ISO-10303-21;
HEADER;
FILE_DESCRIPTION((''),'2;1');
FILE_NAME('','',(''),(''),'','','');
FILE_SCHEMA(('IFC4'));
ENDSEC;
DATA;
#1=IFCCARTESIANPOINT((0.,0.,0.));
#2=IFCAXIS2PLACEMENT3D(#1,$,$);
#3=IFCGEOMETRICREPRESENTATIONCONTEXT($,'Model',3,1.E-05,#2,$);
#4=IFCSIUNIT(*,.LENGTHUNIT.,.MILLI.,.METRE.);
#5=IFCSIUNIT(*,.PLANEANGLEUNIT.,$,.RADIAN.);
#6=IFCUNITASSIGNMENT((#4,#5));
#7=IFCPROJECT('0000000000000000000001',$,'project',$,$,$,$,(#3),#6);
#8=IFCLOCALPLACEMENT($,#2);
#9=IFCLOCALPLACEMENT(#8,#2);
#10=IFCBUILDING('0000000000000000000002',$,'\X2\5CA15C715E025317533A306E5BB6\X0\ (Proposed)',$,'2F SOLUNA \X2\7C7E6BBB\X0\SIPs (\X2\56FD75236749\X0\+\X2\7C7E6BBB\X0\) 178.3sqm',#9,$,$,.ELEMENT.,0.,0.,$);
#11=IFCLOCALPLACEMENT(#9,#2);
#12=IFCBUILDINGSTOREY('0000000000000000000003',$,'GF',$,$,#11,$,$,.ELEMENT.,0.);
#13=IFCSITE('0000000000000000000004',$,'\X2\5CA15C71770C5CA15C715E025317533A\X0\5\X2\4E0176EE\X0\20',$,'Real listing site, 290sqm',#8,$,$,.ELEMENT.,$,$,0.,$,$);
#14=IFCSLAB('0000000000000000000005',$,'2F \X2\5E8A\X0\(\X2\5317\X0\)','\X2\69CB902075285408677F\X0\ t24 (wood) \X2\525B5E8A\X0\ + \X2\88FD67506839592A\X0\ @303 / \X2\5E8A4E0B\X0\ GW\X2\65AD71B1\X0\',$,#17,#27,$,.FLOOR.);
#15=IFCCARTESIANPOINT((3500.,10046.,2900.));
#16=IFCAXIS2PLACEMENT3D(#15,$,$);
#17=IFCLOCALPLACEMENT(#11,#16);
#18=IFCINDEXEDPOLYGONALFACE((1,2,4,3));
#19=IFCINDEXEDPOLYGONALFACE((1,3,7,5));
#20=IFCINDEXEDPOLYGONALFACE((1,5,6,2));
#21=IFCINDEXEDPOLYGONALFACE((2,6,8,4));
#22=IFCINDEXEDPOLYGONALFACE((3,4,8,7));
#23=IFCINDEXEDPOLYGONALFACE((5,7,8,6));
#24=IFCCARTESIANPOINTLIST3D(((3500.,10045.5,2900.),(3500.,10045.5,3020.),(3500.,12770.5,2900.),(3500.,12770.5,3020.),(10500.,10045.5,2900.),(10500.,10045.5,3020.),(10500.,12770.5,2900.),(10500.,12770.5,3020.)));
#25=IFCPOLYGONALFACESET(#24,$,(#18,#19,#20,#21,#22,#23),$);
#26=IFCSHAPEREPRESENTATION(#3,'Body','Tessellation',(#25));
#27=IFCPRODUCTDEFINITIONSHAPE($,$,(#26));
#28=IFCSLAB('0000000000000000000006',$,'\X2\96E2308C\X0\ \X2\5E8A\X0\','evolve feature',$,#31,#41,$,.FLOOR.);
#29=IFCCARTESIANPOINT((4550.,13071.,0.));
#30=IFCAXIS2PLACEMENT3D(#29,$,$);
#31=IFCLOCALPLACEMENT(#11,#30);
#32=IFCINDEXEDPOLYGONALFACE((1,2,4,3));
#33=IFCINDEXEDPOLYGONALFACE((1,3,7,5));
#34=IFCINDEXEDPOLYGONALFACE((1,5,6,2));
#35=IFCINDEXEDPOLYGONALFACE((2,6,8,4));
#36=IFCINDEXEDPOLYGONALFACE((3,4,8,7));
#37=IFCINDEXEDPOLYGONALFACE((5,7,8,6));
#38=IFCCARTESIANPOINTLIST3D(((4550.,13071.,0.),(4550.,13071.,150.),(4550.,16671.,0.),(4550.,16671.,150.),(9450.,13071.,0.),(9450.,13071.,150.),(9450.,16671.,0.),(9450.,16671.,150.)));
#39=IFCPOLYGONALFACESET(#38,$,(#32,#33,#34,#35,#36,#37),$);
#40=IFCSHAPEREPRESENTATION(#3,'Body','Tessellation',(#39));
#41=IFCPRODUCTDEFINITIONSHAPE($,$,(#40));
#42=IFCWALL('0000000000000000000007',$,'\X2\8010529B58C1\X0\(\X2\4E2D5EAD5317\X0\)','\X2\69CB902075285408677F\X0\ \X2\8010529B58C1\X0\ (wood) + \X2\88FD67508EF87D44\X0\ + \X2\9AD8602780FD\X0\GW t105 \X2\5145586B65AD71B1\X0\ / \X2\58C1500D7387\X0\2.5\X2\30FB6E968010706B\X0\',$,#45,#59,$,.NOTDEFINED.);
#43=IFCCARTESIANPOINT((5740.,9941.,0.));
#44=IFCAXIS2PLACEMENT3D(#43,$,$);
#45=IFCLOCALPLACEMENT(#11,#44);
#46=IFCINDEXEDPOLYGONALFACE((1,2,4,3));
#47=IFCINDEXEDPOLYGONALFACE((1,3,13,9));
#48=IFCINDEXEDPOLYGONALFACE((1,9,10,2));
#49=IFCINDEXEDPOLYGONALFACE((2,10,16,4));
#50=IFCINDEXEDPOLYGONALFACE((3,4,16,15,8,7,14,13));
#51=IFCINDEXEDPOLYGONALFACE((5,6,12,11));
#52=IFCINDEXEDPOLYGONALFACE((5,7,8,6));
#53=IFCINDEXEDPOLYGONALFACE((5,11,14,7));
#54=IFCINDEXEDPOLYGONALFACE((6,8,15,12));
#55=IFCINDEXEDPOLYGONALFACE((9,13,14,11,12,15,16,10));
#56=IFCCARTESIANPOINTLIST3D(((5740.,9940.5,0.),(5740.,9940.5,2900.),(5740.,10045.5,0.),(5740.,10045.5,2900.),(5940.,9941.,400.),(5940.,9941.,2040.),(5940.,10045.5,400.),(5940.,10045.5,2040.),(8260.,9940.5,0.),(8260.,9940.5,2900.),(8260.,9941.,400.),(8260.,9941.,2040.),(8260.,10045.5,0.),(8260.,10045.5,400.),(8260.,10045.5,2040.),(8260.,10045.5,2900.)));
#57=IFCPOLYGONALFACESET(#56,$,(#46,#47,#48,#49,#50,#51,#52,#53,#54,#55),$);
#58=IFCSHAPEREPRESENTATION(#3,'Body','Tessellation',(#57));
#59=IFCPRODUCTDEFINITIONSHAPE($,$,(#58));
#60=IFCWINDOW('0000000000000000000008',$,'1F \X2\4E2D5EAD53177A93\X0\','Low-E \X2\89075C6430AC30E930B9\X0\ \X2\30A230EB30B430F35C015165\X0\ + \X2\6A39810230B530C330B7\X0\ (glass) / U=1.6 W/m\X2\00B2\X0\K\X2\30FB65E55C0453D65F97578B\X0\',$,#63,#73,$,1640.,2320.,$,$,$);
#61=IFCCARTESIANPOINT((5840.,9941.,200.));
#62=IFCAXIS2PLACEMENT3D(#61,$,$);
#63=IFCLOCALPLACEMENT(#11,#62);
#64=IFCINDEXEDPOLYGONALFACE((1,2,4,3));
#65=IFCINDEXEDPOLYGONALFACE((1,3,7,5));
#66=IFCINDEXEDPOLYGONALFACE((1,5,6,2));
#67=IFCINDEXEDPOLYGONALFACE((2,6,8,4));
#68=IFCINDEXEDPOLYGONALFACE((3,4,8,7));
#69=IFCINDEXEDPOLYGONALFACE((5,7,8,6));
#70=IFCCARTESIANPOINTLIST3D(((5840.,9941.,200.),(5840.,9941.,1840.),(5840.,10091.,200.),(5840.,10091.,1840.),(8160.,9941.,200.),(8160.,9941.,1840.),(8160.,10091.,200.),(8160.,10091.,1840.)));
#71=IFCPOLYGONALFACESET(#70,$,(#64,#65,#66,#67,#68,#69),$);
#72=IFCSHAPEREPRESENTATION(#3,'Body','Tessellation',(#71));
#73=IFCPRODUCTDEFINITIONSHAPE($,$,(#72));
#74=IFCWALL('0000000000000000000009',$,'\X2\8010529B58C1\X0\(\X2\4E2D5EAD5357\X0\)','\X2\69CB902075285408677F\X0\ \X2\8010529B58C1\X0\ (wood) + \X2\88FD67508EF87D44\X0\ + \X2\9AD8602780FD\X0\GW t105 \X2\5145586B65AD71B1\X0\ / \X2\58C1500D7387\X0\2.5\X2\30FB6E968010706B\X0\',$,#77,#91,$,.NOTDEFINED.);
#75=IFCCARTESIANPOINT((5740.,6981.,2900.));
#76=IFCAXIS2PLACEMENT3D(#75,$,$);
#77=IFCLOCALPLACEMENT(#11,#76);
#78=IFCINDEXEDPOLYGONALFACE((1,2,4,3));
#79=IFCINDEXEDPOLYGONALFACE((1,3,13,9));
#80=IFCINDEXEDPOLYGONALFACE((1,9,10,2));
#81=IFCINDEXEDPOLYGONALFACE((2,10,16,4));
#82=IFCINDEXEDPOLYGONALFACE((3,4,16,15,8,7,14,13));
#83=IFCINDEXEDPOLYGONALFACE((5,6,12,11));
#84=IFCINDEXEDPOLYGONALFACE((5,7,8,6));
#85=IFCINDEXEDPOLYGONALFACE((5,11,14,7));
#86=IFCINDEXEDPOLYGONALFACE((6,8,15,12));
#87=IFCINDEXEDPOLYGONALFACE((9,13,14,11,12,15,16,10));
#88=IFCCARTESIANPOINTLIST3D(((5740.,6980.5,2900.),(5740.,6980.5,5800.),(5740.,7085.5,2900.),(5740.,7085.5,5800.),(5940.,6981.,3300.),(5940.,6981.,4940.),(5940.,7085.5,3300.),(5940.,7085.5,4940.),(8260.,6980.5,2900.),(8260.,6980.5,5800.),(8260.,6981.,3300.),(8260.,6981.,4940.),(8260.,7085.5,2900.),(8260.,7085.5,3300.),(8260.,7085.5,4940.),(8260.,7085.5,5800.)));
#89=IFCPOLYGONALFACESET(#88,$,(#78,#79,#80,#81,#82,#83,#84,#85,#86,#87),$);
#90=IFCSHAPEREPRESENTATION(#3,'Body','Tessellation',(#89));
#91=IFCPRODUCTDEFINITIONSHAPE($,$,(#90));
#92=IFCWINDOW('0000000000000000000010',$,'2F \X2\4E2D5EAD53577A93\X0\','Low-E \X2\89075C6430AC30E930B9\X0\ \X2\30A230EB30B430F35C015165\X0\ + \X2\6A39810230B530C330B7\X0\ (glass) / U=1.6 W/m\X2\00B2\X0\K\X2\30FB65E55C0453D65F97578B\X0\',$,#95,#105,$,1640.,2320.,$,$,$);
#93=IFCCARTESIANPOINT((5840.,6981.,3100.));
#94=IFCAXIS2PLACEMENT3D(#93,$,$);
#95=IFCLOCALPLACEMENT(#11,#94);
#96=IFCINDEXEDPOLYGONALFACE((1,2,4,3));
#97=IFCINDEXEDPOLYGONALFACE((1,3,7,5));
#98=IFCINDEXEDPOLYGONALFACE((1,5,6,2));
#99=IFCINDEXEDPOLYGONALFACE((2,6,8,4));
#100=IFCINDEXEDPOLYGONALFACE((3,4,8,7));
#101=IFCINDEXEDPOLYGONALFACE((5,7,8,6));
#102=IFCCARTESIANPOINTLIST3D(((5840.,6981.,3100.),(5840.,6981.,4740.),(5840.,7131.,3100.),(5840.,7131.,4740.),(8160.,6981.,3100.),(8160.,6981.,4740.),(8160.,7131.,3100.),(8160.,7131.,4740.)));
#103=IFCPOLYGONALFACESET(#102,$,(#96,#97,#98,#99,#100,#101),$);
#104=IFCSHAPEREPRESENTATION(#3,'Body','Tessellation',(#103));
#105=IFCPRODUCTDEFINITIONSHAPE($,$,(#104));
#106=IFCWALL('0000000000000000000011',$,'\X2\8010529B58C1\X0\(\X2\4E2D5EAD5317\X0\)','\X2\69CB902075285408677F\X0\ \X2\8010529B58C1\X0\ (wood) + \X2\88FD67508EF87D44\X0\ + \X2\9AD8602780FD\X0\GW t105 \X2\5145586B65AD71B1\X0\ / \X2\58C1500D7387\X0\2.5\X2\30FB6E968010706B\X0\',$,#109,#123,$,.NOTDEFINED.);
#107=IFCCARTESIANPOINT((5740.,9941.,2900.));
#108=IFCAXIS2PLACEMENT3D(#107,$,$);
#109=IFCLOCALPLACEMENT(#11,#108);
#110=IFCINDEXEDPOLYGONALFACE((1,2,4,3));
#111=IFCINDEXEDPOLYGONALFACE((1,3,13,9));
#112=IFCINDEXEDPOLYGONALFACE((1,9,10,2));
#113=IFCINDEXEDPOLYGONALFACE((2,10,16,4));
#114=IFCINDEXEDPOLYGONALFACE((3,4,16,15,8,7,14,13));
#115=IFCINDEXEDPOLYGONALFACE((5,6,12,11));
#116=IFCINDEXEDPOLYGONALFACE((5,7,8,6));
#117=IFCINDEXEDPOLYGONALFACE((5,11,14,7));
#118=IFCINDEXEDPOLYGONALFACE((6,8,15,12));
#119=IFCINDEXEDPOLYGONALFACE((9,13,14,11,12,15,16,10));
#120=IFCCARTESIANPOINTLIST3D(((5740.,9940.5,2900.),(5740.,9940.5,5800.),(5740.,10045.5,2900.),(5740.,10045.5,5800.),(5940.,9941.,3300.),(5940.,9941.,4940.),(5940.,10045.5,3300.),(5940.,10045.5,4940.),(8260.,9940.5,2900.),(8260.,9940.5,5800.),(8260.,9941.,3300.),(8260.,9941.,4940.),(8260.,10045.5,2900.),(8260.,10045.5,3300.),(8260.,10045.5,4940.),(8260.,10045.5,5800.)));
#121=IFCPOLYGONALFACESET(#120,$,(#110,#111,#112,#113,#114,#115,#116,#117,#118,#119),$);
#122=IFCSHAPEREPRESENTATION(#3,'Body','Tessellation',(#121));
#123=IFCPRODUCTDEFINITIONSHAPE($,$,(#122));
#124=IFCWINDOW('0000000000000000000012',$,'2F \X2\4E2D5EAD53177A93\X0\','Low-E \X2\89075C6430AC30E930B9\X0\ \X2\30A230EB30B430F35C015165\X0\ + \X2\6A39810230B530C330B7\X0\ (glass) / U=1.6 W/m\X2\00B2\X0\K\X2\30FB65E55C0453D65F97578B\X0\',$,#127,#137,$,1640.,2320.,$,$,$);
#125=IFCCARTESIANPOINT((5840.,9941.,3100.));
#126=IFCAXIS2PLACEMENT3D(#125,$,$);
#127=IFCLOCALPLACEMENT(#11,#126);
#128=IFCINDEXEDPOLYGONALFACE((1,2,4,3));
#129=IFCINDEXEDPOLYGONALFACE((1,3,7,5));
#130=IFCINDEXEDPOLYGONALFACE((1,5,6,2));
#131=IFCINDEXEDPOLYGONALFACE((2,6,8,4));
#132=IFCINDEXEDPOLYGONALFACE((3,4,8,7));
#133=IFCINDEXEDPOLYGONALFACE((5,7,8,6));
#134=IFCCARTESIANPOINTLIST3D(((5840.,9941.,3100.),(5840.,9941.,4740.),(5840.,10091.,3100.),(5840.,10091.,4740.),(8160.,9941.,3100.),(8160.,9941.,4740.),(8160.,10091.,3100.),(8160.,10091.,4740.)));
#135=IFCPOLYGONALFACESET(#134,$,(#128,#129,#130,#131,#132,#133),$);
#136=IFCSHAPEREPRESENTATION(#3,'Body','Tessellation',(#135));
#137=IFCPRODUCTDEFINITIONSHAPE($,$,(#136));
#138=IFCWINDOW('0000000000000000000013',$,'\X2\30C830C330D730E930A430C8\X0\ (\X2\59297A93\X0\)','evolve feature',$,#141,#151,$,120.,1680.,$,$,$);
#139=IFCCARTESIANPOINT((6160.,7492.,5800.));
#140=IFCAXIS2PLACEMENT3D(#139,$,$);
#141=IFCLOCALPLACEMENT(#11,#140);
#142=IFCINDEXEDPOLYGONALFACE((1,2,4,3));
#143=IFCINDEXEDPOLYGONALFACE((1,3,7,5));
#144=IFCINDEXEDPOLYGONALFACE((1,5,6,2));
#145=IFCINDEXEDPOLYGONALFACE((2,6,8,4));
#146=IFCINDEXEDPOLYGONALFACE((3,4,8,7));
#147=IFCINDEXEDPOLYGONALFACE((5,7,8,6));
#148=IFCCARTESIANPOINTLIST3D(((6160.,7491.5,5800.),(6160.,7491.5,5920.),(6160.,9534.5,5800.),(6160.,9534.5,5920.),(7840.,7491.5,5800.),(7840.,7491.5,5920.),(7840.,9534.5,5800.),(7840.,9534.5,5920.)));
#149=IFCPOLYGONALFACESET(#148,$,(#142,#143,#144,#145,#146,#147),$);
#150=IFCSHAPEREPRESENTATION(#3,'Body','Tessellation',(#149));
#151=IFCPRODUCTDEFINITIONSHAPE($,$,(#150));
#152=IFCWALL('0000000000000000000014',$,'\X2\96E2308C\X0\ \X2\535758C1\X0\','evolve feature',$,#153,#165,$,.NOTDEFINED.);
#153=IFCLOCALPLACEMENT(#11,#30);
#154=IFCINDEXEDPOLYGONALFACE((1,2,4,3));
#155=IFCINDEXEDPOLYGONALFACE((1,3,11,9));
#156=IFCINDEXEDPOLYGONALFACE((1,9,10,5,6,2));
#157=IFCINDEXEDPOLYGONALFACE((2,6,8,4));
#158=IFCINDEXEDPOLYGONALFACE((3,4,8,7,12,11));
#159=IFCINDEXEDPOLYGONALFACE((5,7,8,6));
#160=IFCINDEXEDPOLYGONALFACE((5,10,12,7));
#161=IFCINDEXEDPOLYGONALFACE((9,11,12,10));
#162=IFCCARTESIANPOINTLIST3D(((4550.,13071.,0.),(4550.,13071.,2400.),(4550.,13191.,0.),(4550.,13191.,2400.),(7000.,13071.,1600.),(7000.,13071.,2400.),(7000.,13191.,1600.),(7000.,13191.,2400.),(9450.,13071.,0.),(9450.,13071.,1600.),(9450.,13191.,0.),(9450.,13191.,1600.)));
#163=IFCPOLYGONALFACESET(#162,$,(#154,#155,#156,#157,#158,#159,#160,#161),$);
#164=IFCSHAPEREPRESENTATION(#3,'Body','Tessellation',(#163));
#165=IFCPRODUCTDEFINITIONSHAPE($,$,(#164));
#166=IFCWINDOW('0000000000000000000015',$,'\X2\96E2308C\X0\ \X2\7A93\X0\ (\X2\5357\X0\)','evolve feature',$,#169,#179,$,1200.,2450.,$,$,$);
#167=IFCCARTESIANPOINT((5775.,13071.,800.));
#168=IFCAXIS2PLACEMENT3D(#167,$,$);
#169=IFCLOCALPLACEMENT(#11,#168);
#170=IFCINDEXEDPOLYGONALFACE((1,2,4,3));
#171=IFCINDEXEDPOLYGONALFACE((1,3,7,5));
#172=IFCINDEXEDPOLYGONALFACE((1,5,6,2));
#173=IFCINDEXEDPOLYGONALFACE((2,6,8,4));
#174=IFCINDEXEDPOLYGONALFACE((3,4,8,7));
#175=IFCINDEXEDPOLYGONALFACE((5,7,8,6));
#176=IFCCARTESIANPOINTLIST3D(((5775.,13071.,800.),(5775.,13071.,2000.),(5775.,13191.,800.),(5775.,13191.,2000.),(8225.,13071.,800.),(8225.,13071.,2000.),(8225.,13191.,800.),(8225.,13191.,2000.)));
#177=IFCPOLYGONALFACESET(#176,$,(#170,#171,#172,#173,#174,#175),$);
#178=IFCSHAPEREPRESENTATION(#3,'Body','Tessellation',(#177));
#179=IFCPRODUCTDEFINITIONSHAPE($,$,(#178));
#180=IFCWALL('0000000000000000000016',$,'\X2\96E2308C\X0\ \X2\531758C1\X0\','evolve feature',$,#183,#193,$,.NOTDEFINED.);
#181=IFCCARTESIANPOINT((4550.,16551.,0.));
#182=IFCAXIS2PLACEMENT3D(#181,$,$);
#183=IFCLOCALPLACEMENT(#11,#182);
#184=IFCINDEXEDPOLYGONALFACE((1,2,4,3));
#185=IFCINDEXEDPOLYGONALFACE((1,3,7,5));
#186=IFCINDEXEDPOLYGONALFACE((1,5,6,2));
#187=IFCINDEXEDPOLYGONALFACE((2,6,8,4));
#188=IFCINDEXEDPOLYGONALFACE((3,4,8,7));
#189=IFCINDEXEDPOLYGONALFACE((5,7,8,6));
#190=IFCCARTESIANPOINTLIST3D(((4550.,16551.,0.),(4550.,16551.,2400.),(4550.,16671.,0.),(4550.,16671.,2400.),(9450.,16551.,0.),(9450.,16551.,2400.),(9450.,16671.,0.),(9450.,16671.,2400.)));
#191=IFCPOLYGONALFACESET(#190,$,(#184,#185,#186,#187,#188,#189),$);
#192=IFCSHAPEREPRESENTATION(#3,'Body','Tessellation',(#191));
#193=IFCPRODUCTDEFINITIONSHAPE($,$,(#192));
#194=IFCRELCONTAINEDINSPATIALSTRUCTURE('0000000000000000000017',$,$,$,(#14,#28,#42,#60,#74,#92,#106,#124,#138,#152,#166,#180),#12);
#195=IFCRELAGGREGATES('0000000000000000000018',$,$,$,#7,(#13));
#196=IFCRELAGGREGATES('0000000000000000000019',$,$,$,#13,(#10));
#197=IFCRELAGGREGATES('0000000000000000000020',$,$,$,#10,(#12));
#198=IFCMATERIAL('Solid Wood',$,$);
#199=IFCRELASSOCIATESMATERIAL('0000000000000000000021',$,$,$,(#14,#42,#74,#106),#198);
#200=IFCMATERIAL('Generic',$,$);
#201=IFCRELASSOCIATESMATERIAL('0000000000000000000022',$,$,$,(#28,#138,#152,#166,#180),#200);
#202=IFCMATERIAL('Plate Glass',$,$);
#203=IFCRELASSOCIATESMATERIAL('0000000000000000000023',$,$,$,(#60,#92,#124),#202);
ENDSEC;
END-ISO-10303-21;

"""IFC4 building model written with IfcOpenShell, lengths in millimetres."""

from ifc_helpers import new_model, si_unit, frame, frame_2d, origin, place, context, project, spatial, rectangle, extrude, material, element, fill, save


model = new_model("IFC4")

# Units and contexts
model_context = context("Model", 3, precision=1e-05, world=origin())
ifc_project = project(units=[si_unit("LENGTHUNIT", "METRE", prefix="MILLI"), si_unit("PLANEANGLEUNIT", "RADIAN")], contexts=[model_context])

# Site, building, storey
site_placement = place(None, origin())
site = spatial("IfcSite", under=ifc_project, at=site_placement, Name="岡山県岡山市北区5丁目20", ObjectType="Real listing site, 290sqm", CompositionType="ELEMENT", RefElevation=0.0)
building_placement = place(site_placement, origin())
building = spatial("IfcBuilding", under=site, at=building_placement, Name="岡山市北区の家 (Proposed)", ObjectType="2F SOLUNA 籾殻SIPs (国産杉+籾殻) 178.3sqm", CompositionType="ELEMENT", ElevationOfRefHeight=0.0, ElevationOfTerrain=0.0)
storey_placement = place(building_placement, origin())
storey = spatial("IfcBuildingStorey", under=building, at=storey_placement, Name="GF", CompositionType="ELEMENT", Elevation=0.0)

# Slabs
ifc_material_1 = material(Name="Solid Wood")
slab_1_placement = place(storey_placement, frame((3500.0, 10046.0, 2900.0)))
element("IfcSlab", 1, at=slab_1_placement, inside=storey, material=ifc_material_1, Name="2F 床(北)", Description="構造用合板 t24 (wood) 剛床 + 製材根太 @303 / 床下 GW断熱", PredefinedType="FLOOR", context=model_context, shape_type="SweptSolid", body=[
    extrude(rectangle(XDim=7000.0, YDim=2725.0, at=frame_2d((3500.0, 1362.0))), frame((3500.0, 10046.0, 2900.0)), (0.0, 0.0, 1.0), 120.0),
])
ifc_material_2 = material(Name="Generic")
slab_2_placement = place(storey_placement, frame((4550.0, 13071.0, 0.0)))
element("IfcSlab", 2, at=slab_2_placement, inside=storey, material=ifc_material_2, Name="離れ 床", Description="evolve feature", PredefinedType="FLOOR", context=model_context, shape_type="SweptSolid", body=[
    extrude(rectangle(XDim=4900.0, YDim=3600.0, at=frame_2d((2450.0, 1800.0))), frame((4550.0, 13071.0, 0.0)), (0.0, 0.0, 1.0), 150.0),
])

# Wall, opening, window
wall_1_placement = place(storey_placement, frame((5740.0, 9941.0, 0.0)))
wall_1 = element("IfcWall", 3, at=wall_1_placement, inside=storey, material=ifc_material_1, Name="耐力壁(中庭北)", Description="構造用合板 耐力壁 (wood) + 製材軸組 + 高性能GW t105 充填断熱 / 壁倍率2.5・準耐火", PredefinedType="NOTDEFINED", context=model_context, shape_type="SweptSolid", body=[
    extrude(rectangle(XDim=2520.0, YDim=105.0, at=frame_2d((1260.0, 52.0))), frame((5740.0, 9941.0, 0.0)), (0.0, 0.0, 1.0), 2900.0),
])
opening_1_placement = place(storey_placement, frame((5840.0, 9941.0, 200.0)))
opening_1 = element("IfcOpeningElement", 4, at=opening_1_placement, cuts=wall_1, PredefinedType="NOTDEFINED", context=model_context, shape_type="SweptSolid", body=[
    extrude(rectangle(XDim=2320.0, YDim=150.0, at=frame_2d((1160.0, 75.0))), frame((5840.0, 9941.0, 200.0)), (0.0, 0.0, 1.0), 1640.0),
])
ifc_material_3 = material(Name="Plate Glass")
window_1_placement = place(storey_placement, frame((5840.0, 9941.0, 200.0)))
window_1 = element("IfcWindow", 5, at=window_1_placement, inside=storey, material=ifc_material_3, Name="1F 中庭北窓", Description="Low-E 複層ガラス アルゴン封入 + 樹脂サッシ (glass) / U=1.6 W/m²K・日射取得型", OverallHeight=1640.0, OverallWidth=2320.0, context=model_context, shape_type="SweptSolid", body=[
    extrude(rectangle(XDim=2320.0, YDim=150.0, at=frame_2d((1160.0, 75.0))), frame((5840.0, 9941.0, 200.0)), (0.0, 0.0, 1.0), 1640.0),
])
fill(opening_1, window_1)

# Walls, openings, windows
wall_2_placement = place(storey_placement, frame((5740.0, 6981.0, 2900.0)))
wall_2 = element("IfcWall", 6, at=wall_2_placement, inside=storey, material=ifc_material_1, Name="耐力壁(中庭南)", Description="構造用合板 耐力壁 (wood) + 製材軸組 + 高性能GW t105 充填断熱 / 壁倍率2.5・準耐火", PredefinedType="NOTDEFINED", context=model_context, shape_type="SweptSolid", body=[
    extrude(rectangle(XDim=2520.0, YDim=105.0, at=frame_2d((1260.0, 52.0))), frame((5740.0, 6981.0, 2900.0)), (0.0, 0.0, 1.0), 2900.0),
])
opening_2_placement = place(storey_placement, frame((5840.0, 6981.0, 3100.0)))
opening_2 = element("IfcOpeningElement", 7, at=opening_2_placement, cuts=wall_2, PredefinedType="NOTDEFINED", context=model_context, shape_type="SweptSolid", body=[
    extrude(rectangle(XDim=2320.0, YDim=150.0, at=frame_2d((1160.0, 75.0))), frame((5840.0, 6981.0, 3100.0)), (0.0, 0.0, 1.0), 1640.0),
])
window_2_placement = place(storey_placement, frame((5840.0, 6981.0, 3100.0)))
window_2 = element("IfcWindow", 8, at=window_2_placement, inside=storey, material=ifc_material_3, Name="2F 中庭南窓", Description="Low-E 複層ガラス アルゴン封入 + 樹脂サッシ (glass) / U=1.6 W/m²K・日射取得型", OverallHeight=1640.0, OverallWidth=2320.0, context=model_context, shape_type="SweptSolid", body=[
    extrude(rectangle(XDim=2320.0, YDim=150.0, at=frame_2d((1160.0, 75.0))), frame((5840.0, 6981.0, 3100.0)), (0.0, 0.0, 1.0), 1640.0),
])
fill(opening_2, window_2)
wall_3_placement = place(storey_placement, frame((5740.0, 9941.0, 2900.0)))
wall_3 = element("IfcWall", 9, at=wall_3_placement, inside=storey, material=ifc_material_1, Name="耐力壁(中庭北)", Description="構造用合板 耐力壁 (wood) + 製材軸組 + 高性能GW t105 充填断熱 / 壁倍率2.5・準耐火", PredefinedType="NOTDEFINED", context=model_context, shape_type="SweptSolid", body=[
    extrude(rectangle(XDim=2520.0, YDim=105.0, at=frame_2d((1260.0, 52.0))), frame((5740.0, 9941.0, 2900.0)), (0.0, 0.0, 1.0), 2900.0),
])
opening_3_placement = place(storey_placement, frame((5840.0, 9941.0, 3100.0)))
opening_3 = element("IfcOpeningElement", 10, at=opening_3_placement, cuts=wall_3, PredefinedType="NOTDEFINED", context=model_context, shape_type="SweptSolid", body=[
    extrude(rectangle(XDim=2320.0, YDim=150.0, at=frame_2d((1160.0, 75.0))), frame((5840.0, 9941.0, 3100.0)), (0.0, 0.0, 1.0), 1640.0),
])
window_3_placement = place(storey_placement, frame((5840.0, 9941.0, 3100.0)))
window_3 = element("IfcWindow", 11, at=window_3_placement, inside=storey, material=ifc_material_3, Name="2F 中庭北窓", Description="Low-E 複層ガラス アルゴン封入 + 樹脂サッシ (glass) / U=1.6 W/m²K・日射取得型", OverallHeight=1640.0, OverallWidth=2320.0, context=model_context, shape_type="SweptSolid", body=[
    extrude(rectangle(XDim=2320.0, YDim=150.0, at=frame_2d((1160.0, 75.0))), frame((5840.0, 9941.0, 3100.0)), (0.0, 0.0, 1.0), 1640.0),
])
fill(opening_3, window_3)

# Window
window_4_placement = place(storey_placement, frame((6160.0, 7492.0, 5800.0)))
element("IfcWindow", 12, at=window_4_placement, inside=storey, material=ifc_material_2, Name="トップライト (天窓)", Description="evolve feature", OverallHeight=120.0, OverallWidth=1680.0, context=model_context, shape_type="SweptSolid", body=[
    extrude(rectangle(XDim=1680.0, YDim=2043.0, at=frame_2d((840.0, 1021.0))), frame((6160.0, 7492.0, 5800.0)), (0.0, 0.0, 1.0), 120.0),
])

# Wall, opening, window
wall_4_placement = place(storey_placement, frame((4550.0, 13071.0, 0.0)))
wall_4 = element("IfcWall", 13, at=wall_4_placement, inside=storey, material=ifc_material_2, Name="離れ 南壁", Description="evolve feature", PredefinedType="NOTDEFINED", context=model_context, shape_type="SweptSolid", body=[
    extrude(rectangle(XDim=4900.0, YDim=120.0, at=frame_2d((2450.0, 60.0))), frame((4550.0, 13071.0, 0.0)), (0.0, 0.0, 1.0), 2400.0),
])
opening_4_placement = place(storey_placement, frame((5775.0, 13071.0, 800.0)))
opening_4 = element("IfcOpeningElement", 14, at=opening_4_placement, cuts=wall_4, PredefinedType="NOTDEFINED", context=model_context, shape_type="SweptSolid", body=[
    extrude(rectangle(XDim=2450.0, YDim=120.0, at=frame_2d((1225.0, 60.0))), frame((5775.0, 13071.0, 800.0)), (0.0, 0.0, 1.0), 1200.0),
])
window_5_placement = place(storey_placement, frame((5775.0, 13071.0, 800.0)))
window_5 = element("IfcWindow", 15, at=window_5_placement, inside=storey, material=ifc_material_2, Name="離れ 窓 (南)", Description="evolve feature", OverallHeight=1200.0, OverallWidth=2450.0, context=model_context, shape_type="SweptSolid", body=[
    extrude(rectangle(XDim=2450.0, YDim=120.0, at=frame_2d((1225.0, 60.0))), frame((5775.0, 13071.0, 800.0)), (0.0, 0.0, 1.0), 1200.0),
])
fill(opening_4, window_5)

# Wall
wall_5_placement = place(storey_placement, frame((4550.0, 16551.0, 0.0)))
element("IfcWall", 16, at=wall_5_placement, inside=storey, material=ifc_material_2, Name="離れ 北壁", Description="evolve feature", PredefinedType="NOTDEFINED", context=model_context, shape_type="SweptSolid", body=[
    extrude(rectangle(XDim=4900.0, YDim=120.0, at=frame_2d((2450.0, 60.0))), frame((4550.0, 16551.0, 0.0)), (0.0, 0.0, 1.0), 2400.0),
])

save(model, "model.ifc")
